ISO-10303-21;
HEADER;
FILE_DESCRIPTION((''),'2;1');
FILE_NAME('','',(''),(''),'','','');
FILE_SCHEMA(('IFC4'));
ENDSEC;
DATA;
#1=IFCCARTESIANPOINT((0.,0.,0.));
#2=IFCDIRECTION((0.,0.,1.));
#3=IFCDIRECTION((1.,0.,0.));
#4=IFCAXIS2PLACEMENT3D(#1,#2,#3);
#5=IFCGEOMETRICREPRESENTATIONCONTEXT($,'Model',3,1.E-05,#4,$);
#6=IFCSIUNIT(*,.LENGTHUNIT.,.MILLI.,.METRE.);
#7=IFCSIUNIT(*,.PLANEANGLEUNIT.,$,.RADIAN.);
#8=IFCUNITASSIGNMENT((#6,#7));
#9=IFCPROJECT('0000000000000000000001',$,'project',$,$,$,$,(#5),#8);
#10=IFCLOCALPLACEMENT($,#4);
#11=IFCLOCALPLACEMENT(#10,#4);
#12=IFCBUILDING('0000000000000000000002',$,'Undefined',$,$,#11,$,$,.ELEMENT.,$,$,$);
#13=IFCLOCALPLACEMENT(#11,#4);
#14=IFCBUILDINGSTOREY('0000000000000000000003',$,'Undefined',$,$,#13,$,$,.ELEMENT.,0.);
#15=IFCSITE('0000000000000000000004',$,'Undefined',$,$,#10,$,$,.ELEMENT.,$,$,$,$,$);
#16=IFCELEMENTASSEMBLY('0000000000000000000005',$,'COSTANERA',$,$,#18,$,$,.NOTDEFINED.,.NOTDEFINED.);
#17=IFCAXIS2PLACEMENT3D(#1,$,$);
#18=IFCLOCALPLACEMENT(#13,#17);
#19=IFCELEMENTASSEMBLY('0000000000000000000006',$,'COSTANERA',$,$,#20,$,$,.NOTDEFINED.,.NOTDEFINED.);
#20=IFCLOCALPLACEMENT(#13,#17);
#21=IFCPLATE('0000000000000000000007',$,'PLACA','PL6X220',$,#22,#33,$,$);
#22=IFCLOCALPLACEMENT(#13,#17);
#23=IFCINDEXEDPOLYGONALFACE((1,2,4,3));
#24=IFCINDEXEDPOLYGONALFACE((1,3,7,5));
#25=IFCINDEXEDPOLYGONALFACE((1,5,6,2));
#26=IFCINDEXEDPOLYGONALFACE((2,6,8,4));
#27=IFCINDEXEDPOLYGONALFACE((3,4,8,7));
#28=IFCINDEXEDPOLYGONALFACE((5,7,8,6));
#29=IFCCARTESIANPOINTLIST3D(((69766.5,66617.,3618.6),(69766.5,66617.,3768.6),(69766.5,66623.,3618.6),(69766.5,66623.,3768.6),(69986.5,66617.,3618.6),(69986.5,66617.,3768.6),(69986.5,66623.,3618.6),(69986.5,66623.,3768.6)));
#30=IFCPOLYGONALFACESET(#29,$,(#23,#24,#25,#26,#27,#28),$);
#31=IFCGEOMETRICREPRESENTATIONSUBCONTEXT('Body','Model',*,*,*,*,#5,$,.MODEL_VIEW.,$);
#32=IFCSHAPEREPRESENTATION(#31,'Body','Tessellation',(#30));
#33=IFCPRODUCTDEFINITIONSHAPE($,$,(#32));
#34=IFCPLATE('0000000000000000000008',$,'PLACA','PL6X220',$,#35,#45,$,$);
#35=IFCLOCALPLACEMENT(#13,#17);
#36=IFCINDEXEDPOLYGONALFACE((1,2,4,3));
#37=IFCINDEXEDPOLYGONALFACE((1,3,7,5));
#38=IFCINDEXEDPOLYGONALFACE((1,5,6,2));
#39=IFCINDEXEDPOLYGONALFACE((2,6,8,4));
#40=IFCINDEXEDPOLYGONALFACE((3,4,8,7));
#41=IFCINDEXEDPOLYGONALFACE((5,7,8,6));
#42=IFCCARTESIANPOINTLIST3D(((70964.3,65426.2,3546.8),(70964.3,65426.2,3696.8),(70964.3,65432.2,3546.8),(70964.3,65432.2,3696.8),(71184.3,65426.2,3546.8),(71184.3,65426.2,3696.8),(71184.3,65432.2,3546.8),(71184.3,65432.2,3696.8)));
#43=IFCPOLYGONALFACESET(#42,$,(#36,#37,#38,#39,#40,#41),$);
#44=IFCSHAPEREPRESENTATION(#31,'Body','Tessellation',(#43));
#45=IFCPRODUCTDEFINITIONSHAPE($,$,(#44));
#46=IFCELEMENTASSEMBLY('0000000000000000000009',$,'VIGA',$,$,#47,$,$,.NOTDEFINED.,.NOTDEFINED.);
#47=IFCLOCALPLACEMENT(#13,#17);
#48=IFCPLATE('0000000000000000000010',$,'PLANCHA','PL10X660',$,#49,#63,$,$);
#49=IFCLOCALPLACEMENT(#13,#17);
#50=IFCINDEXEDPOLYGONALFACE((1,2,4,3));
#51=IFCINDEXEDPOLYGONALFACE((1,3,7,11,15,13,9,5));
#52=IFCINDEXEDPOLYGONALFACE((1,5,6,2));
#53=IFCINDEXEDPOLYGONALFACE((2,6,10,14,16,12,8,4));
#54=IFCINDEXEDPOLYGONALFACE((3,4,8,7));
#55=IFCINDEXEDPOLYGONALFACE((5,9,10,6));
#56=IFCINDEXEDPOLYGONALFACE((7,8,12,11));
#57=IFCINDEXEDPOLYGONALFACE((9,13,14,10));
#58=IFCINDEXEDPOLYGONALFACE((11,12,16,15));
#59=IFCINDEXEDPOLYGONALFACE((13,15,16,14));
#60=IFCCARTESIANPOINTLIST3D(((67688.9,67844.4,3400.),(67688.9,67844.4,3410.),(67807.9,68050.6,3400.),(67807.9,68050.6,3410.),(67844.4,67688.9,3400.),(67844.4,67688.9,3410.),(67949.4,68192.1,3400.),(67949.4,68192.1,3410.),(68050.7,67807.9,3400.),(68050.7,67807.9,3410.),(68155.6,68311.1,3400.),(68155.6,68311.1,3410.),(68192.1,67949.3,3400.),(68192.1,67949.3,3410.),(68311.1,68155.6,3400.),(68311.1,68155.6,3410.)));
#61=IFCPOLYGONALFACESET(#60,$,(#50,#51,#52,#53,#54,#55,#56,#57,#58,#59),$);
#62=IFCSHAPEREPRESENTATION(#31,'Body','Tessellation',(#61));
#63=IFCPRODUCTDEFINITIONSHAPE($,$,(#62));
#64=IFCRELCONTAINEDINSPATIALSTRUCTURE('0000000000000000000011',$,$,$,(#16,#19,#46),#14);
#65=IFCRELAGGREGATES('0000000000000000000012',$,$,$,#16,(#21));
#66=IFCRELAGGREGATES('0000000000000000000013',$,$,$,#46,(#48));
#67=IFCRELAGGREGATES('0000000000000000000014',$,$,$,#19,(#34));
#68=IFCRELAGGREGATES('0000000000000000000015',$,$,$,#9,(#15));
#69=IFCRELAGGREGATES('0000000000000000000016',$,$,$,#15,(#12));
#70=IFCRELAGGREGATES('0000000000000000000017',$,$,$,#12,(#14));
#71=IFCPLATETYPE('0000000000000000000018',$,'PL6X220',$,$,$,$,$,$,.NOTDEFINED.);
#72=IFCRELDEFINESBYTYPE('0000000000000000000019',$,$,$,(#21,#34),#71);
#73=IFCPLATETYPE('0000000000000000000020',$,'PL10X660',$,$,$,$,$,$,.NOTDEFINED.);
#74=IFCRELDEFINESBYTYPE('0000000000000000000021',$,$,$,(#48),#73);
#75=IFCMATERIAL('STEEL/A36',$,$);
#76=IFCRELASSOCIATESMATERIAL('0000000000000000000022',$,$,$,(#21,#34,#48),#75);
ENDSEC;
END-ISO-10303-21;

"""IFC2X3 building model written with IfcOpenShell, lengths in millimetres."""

from ifc_helpers import new_model, si_unit, frame, origin_with_axes, place, context, subcontext, project, spatial, polyline, outline, extrude, material, type_object, element, aggregate, save


model = new_model("IFC2X3")

# Units and contexts
model_context = context("Model", 3, precision=1e-05, world=origin_with_axes())
body_context = subcontext(model_context, "Body", "Model", "MODEL_VIEW")
ifc_project = project(units=[si_unit("LENGTHUNIT", "METRE", prefix="MILLI"), si_unit("PLANEANGLEUNIT", "RADIAN")], contexts=[model_context])

# Site, building, storey
site_placement = place(None, origin_with_axes())
site = spatial("IfcSite", under=ifc_project, at=site_placement, Name="Undefined", CompositionType="ELEMENT")
building_placement = place(site_placement, origin_with_axes())
building = spatial("IfcBuilding", under=site, at=building_placement, Name="Undefined", CompositionType="ELEMENT")
storey_placement = place(building_placement, origin_with_axes())
storey = spatial("IfcBuildingStorey", under=building, at=storey_placement, Name="Undefined", CompositionType="ELEMENT", Elevation=0.0)

# Element assembly
ifc_material_1 = material(Name="STEEL/A36")
assembly_1_placement = place(storey_placement, origin_with_axes())
assembly_1 = element("IfcElementAssembly", 1, at=assembly_1_placement, inside=storey, Name="COSTANERA", AssemblyPlace="NOTDEFINED", PredefinedType="NOTDEFINED")

# Shared definitions
plate_type_1 = type_object("IfcPlateType", Name="PL6X220", PredefinedType="NOTDEFINED")

# Element assembly
assembly_2_placement = place(storey_placement, origin_with_axes())
assembly_2 = element("IfcElementAssembly", 2, at=assembly_2_placement, inside=storey, Name="COSTANERA", AssemblyPlace="NOTDEFINED", PredefinedType="NOTDEFINED")

# Plates
plate_1_placement = place(assembly_1_placement, frame((69876.5, 66620.0, 3618.6), z_axis=(0.0, 1.0, 0.0), x_axis=(0.0, 0.0, 1.0)))
plate_1 = element("IfcPlate", 3, at=plate_1_placement, type_object=plate_type_1, material=ifc_material_1, Name="PLACA", Description="PL6X220", context=body_context, shape_type="SweptSolid", body=[
    extrude(outline(polyline([(0.0, -110.0), (0.0, 110.0), (150.0, 110.0), (150.0, -110.0), (0.0, -110.0)])), frame((0.0, 0.0, -3.0), z_axis=(0.0, 0.0, 1.0), x_axis=(1.0, 0.0, 0.0)), (0.0, 0.0, 1.0), 6.0),
])
aggregate(assembly_1, [plate_1])
plate_2_placement = place(assembly_2_placement, frame((71074.3, 65429.2, 3546.8), z_axis=(0.0, 1.0, 0.0), x_axis=(0.0, 0.0, 1.0)))
plate_2 = element("IfcPlate", 4, at=plate_2_placement, type_object=plate_type_1, material=ifc_material_1, Name="PLACA", Description="PL6X220", context=body_context, shape_type="SweptSolid", body=[
    extrude(outline(polyline([(0.0, -110.0), (0.0, 110.0), (150.0, 110.0), (150.0, -110.0), (0.0, -110.0)])), frame((0.0, 0.0, -3.0), z_axis=(0.0, 0.0, 1.0), x_axis=(1.0, 0.0, 0.0)), (0.0, 0.0, 1.0), 6.0),
])

# Element assembly, plate
assembly_3_placement = place(storey_placement, origin_with_axes())
assembly_3 = element("IfcElementAssembly", 5, at=assembly_3_placement, inside=storey, Name="VIGA", AssemblyPlace="NOTDEFINED", PredefinedType="NOTDEFINED")
plate_type_2 = type_object("IfcPlateType", Name="PL10X660", PredefinedType="NOTDEFINED")
plate_3_placement = place(assembly_3_placement, frame((67807.9, 68050.6, 3405.0), z_axis=(0.0, 0.0, -1.0), x_axis=(0.707107, 0.707107, 0.0)))
plate_3 = element("IfcPlate", 6, at=plate_3_placement, type_object=plate_type_2, material=ifc_material_1, Name="PLANCHA", Description="PL10X660", context=body_context, shape_type="SweptSolid", body=[
    extrude(outline(polyline([(0.0, 0.0), (200.0, 0.0), (430.0, 61.6), (430.0, 281.6), (200.0, 343.3), (0.0, 343.3), (-230.0, 281.6), (-230.0, 61.6), (0.0, 0.0)])), frame((0.0, 0.0, -5.0), z_axis=(0.0, 0.0, 1.0), x_axis=(1.0, 0.0, 0.0)), (0.0, 0.0, 1.0), 10.0),
])
aggregate(assembly_3, [plate_3])

aggregate(assembly_2, [plate_2])

save(model, "model.ifc")
